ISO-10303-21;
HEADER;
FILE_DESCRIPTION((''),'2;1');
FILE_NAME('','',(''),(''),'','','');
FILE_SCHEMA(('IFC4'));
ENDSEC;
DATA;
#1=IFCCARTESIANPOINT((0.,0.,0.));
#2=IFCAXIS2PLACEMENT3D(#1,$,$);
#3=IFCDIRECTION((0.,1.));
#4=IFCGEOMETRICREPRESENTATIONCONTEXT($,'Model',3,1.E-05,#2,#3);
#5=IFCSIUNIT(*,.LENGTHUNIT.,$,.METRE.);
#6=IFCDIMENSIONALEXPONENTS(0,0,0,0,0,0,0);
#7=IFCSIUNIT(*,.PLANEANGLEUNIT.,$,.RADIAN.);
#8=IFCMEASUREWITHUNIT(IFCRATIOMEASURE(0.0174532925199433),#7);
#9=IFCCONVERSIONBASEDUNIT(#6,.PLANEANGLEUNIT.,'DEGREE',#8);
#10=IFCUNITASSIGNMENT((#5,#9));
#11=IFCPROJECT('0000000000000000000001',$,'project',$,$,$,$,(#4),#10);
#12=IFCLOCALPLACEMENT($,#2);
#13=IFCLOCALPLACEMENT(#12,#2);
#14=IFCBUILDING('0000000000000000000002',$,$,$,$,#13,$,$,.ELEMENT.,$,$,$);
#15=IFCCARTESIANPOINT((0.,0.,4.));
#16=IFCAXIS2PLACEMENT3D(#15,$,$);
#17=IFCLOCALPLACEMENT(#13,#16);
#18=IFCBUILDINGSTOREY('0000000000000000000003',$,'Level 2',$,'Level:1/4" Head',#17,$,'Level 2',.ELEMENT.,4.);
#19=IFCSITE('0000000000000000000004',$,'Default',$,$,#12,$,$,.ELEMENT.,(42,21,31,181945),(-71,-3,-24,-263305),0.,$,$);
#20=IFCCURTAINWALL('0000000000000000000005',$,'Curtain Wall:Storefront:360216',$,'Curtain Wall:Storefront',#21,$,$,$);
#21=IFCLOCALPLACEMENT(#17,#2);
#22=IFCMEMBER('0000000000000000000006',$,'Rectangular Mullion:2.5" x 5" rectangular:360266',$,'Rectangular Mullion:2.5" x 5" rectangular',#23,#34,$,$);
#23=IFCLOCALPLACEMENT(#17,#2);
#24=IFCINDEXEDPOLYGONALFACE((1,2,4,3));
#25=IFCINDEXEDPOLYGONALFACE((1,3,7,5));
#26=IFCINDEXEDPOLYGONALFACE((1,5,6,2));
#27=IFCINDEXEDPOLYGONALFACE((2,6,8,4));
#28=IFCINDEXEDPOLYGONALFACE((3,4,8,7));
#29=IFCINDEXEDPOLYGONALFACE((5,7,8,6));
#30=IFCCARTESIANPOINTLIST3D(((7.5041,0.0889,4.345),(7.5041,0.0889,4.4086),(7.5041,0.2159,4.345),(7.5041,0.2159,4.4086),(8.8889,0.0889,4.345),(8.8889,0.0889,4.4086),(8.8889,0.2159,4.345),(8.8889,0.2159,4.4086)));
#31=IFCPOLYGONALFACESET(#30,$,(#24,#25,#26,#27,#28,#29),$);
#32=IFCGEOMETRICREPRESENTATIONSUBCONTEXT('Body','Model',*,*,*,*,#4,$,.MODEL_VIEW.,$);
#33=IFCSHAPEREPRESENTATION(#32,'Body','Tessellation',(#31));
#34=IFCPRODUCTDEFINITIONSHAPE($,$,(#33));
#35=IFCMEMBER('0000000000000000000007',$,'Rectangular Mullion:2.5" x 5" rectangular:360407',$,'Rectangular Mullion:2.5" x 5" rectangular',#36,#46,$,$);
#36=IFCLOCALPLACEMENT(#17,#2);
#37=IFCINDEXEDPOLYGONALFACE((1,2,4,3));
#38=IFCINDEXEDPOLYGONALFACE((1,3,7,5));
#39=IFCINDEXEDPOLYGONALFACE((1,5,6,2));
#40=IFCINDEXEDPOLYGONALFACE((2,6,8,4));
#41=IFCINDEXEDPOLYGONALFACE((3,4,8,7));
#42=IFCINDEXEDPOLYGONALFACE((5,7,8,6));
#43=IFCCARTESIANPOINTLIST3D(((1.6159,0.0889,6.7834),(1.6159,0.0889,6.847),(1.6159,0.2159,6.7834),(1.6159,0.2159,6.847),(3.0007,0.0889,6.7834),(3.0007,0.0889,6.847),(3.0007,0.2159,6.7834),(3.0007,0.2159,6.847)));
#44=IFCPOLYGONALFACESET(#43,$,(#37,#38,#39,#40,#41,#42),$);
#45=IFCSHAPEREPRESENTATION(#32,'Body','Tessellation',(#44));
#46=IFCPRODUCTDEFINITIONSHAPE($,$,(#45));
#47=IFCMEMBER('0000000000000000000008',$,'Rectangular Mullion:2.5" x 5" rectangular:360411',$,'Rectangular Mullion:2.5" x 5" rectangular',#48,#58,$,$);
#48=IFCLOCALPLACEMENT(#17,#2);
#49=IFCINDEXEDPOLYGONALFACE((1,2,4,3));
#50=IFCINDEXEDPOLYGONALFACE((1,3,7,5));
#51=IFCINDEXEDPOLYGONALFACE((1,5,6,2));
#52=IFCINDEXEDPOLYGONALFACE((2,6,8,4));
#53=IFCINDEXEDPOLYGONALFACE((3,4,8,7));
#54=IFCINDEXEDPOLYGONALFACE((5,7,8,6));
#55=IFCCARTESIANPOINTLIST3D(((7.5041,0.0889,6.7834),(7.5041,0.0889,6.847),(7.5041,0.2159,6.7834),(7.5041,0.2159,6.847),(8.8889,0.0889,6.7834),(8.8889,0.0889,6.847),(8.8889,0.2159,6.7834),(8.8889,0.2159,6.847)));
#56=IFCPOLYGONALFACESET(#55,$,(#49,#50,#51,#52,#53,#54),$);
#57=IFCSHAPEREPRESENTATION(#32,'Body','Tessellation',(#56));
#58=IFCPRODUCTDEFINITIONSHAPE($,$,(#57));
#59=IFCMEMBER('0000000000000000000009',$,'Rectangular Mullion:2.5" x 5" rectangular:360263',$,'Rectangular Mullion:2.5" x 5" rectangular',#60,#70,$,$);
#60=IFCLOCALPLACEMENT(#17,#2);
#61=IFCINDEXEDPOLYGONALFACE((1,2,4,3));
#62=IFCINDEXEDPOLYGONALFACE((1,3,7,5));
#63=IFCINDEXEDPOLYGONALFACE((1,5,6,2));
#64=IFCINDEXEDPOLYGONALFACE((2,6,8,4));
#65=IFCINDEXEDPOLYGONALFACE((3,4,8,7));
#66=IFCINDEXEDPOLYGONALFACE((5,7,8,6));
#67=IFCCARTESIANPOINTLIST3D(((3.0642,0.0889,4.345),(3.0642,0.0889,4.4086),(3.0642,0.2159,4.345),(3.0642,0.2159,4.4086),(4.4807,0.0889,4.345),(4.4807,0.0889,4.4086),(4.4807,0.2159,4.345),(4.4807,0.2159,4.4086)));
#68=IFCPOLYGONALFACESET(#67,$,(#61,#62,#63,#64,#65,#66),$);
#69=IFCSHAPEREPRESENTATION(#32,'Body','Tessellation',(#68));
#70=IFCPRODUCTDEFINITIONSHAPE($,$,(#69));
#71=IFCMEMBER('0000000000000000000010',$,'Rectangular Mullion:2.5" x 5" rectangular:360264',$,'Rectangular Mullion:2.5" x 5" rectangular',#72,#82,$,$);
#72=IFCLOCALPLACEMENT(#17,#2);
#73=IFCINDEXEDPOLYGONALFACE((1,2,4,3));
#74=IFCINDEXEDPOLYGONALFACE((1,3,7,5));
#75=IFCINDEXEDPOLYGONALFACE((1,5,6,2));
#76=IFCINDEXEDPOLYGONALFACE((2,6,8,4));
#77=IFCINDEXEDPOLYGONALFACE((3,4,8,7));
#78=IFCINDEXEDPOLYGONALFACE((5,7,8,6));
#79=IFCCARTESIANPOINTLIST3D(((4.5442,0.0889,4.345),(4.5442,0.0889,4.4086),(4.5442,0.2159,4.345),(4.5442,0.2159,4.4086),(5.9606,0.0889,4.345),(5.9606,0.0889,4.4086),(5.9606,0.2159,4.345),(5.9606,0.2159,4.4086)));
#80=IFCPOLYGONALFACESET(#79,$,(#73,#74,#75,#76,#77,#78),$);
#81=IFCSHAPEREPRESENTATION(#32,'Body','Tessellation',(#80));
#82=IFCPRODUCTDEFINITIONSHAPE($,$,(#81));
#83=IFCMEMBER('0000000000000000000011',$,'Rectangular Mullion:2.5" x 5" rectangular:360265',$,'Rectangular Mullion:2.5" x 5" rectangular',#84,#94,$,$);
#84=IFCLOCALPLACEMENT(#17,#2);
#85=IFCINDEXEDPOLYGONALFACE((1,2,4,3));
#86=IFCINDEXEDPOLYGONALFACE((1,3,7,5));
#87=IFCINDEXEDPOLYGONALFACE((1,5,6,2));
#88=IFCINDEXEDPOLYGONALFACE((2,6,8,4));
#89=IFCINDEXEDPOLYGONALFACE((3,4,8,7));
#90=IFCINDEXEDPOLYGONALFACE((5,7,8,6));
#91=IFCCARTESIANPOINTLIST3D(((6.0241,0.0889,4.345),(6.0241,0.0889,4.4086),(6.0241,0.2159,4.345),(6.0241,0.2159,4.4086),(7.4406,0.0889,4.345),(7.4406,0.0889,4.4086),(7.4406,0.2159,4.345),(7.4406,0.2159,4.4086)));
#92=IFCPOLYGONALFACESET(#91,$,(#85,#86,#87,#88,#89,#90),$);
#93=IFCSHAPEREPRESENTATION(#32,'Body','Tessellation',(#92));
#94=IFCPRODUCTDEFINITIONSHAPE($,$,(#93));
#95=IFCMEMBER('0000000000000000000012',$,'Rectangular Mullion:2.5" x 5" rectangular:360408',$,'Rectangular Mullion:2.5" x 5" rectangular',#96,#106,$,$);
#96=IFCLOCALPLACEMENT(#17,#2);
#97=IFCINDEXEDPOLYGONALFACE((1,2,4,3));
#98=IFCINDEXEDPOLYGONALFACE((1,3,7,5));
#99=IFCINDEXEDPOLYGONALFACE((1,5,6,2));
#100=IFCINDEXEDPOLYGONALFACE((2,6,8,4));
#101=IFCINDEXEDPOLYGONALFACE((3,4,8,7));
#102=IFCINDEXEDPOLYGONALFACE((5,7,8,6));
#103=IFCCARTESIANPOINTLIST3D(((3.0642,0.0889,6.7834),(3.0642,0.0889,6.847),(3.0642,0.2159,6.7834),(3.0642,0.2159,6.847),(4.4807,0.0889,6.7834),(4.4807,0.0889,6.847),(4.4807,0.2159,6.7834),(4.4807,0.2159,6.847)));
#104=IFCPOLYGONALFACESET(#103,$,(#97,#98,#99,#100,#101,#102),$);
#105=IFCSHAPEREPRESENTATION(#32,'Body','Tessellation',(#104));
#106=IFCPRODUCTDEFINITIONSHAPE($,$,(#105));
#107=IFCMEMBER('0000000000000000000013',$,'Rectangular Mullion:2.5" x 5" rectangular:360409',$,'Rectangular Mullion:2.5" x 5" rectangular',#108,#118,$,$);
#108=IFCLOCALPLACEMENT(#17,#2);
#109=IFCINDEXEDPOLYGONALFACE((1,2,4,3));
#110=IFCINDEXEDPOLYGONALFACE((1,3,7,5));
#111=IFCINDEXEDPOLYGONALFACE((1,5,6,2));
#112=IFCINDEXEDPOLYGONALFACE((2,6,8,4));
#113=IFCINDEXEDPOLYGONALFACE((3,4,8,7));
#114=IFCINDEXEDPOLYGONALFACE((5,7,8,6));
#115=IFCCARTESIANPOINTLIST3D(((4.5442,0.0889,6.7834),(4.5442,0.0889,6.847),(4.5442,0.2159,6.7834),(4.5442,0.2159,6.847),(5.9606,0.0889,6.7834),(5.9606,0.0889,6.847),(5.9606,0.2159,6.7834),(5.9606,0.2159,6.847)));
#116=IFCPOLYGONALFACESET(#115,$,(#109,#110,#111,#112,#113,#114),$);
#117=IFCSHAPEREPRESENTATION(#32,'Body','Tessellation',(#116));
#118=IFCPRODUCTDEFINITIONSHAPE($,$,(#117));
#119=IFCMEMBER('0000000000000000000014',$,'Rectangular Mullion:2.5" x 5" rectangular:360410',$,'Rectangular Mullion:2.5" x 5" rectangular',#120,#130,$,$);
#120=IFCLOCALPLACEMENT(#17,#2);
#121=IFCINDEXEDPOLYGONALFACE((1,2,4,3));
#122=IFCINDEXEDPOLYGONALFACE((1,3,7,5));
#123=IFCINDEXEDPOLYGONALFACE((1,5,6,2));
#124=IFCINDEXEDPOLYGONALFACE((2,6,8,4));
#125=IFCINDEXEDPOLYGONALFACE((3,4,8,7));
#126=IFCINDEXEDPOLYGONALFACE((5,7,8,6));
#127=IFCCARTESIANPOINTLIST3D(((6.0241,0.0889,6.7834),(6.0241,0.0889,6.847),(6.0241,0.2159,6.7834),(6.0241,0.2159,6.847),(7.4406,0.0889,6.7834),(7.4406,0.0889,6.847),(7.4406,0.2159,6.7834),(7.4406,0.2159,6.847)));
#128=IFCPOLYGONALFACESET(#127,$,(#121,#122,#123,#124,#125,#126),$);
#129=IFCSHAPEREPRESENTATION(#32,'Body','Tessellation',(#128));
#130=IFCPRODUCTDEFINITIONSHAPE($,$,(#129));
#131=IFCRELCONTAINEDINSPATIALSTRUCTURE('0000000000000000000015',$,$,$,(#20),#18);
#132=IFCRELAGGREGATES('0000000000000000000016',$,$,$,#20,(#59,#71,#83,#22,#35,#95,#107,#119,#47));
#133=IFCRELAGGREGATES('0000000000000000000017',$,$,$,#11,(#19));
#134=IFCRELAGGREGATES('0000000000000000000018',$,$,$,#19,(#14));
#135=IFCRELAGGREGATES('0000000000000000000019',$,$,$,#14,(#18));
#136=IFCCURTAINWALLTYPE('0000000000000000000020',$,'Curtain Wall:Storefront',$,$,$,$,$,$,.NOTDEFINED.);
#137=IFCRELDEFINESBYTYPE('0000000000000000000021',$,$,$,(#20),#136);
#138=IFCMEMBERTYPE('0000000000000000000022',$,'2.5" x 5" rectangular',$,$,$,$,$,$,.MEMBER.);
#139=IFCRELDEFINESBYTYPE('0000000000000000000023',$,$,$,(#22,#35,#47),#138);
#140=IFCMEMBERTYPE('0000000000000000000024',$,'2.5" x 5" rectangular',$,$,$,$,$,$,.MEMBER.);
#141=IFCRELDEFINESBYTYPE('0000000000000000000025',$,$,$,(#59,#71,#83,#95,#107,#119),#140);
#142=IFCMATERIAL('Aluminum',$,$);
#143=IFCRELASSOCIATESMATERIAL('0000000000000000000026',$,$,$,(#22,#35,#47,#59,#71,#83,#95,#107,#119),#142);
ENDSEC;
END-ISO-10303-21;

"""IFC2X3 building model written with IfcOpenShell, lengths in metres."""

from ifc_helpers import new_model, entity, si_unit, converted_unit, direction, frame, origin, origin_2d_with_axis, place, context, subcontext, project, spatial, rectangle, extrude, source, transform, mapped, material, type_object, type_shapes, element, aggregate, save


model = new_model("IFC2X3")

# Units and contexts
model_context = context("Model", 3, precision=1e-05, world=origin(), true_north=direction((0.0, 1.0)))
body_context = subcontext(model_context, "Body", "Model", "MODEL_VIEW")
ifc_project = project(units=[si_unit("LENGTHUNIT", "METRE"), converted_unit("PLANEANGLEUNIT", "DEGREE", entity("IfcRatioMeasure", 0.0174532925199433), si_unit("PLANEANGLEUNIT", "RADIAN"), dimensions=[0, 0, 0, 0, 0, 0, 0])], contexts=[model_context])

# Site, building, storey
site_placement = place(None, origin())
site = spatial("IfcSite", under=ifc_project, at=site_placement, Name="Default", CompositionType="ELEMENT", RefLatitude=(42, 21, 31, 181945), RefLongitude=(-71, -3, -24, -263305), RefElevation=0.0)
building_placement = place(site_placement, origin())
building = spatial("IfcBuilding", under=site, at=building_placement, CompositionType="ELEMENT")
storey_placement = place(building_placement, frame((0.0, 0.0, 4.0)))
storey = spatial("IfcBuildingStorey", under=building, at=storey_placement, Name="Level 2", ObjectType="Level:1/4\" Head", LongName="Level 2", CompositionType="ELEMENT", Elevation=4.0)

# Curtain wall, members
curtain_wall_type = type_object("IfcCurtainWallType", Name="Curtain Wall:Storefront", PredefinedType="NOTDEFINED")
curtain_wall_placement = place(storey_placement, frame((0.0, 0.0, -4.0)))
curtain_wall = element("IfcCurtainWall", 1, at=curtain_wall_placement, inside=storey, type_object=curtain_wall_type, Name="Curtain Wall:Storefront:360216", ObjectType="Curtain Wall:Storefront")
ifc_material_1 = material(Name="Aluminum")
member_type_1 = type_object("IfcMemberType", Name="2.5\" x 5\" rectangular", PredefinedType="MEMBER")
shared_shape_1 = source(origin(), body_context, "Body", "SweptSolid", [
    extrude(rectangle(XDim=0.127, YDim=0.0635, at=origin_2d_with_axis()), frame((0.0, 0.0, -1.3848), z_axis=(0.0, 0.0, 1.0), x_axis=(0.0, -1.0, 0.0)), (0.0, 0.0, 1.0), 1.3848),
])
type_shapes(member_type_1, [shared_shape_1])
member_1_placement = place(storey_placement, frame((8.8889, 0.1524, 4.3768), z_axis=(1.0, 0.0, 0.0), x_axis=(0.0, 0.0, 1.0)))
member_1 = element("IfcMember", 2, at=member_1_placement, type_object=member_type_1, material=ifc_material_1, Name="Rectangular Mullion:2.5\" x 5\" rectangular:360266", ObjectType="Rectangular Mullion:2.5\" x 5\" rectangular", context=body_context, shape_type="MappedRepresentation", body=[
    mapped(shared_shape_1, transform((0.0, 0.0, 0.0), scale=1.0)),
])
member_2_placement = place(storey_placement, frame((3.0007, 0.1524, 6.8152), z_axis=(1.0, 0.0, 0.0), x_axis=(0.0, 0.0, 1.0)))
member_2 = element("IfcMember", 3, at=member_2_placement, type_object=member_type_1, material=ifc_material_1, Name="Rectangular Mullion:2.5\" x 5\" rectangular:360407", ObjectType="Rectangular Mullion:2.5\" x 5\" rectangular", context=body_context, shape_type="MappedRepresentation", body=[
    mapped(shared_shape_1, transform((0.0, 0.0, 0.0), scale=1.0)),
])
member_3_placement = place(storey_placement, frame((8.8889, 0.1524, 6.8152), z_axis=(1.0, 0.0, 0.0), x_axis=(0.0, 0.0, 1.0)))
member_3 = element("IfcMember", 4, at=member_3_placement, type_object=member_type_1, material=ifc_material_1, Name="Rectangular Mullion:2.5\" x 5\" rectangular:360411", ObjectType="Rectangular Mullion:2.5\" x 5\" rectangular", context=body_context, shape_type="MappedRepresentation", body=[
    mapped(shared_shape_1, transform((0.0, 0.0, 0.0), scale=1.0)),
])
member_type_2 = type_object("IfcMemberType", Name="2.5\" x 5\" rectangular", PredefinedType="MEMBER")
shared_shape_2 = source(origin(), body_context, "Body", "SweptSolid", [
    extrude(rectangle(XDim=0.127, YDim=0.0635, at=origin_2d_with_axis()), frame((0.0, 0.0, -1.4165), z_axis=(0.0, 0.0, 1.0), x_axis=(0.0, -1.0, 0.0)), (0.0, 0.0, 1.0), 1.4165),
])
type_shapes(member_type_2, [shared_shape_2])
member_4_placement = place(storey_placement, frame((4.4807, 0.1524, 4.3768), z_axis=(1.0, 0.0, 0.0), x_axis=(0.0, 0.0, 1.0)))
member_4 = element("IfcMember", 5, at=member_4_placement, type_object=member_type_2, material=ifc_material_1, Name="Rectangular Mullion:2.5\" x 5\" rectangular:360263", ObjectType="Rectangular Mullion:2.5\" x 5\" rectangular", context=body_context, shape_type="MappedRepresentation", body=[
    mapped(shared_shape_2, transform((0.0, 0.0, 0.0), scale=1.0)),
])
member_5_placement = place(storey_placement, frame((5.9606, 0.1524, 4.3768), z_axis=(1.0, 0.0, 0.0), x_axis=(0.0, 0.0, 1.0)))
member_5 = element("IfcMember", 6, at=member_5_placement, type_object=member_type_2, material=ifc_material_1, Name="Rectangular Mullion:2.5\" x 5\" rectangular:360264", ObjectType="Rectangular Mullion:2.5\" x 5\" rectangular", context=body_context, shape_type="MappedRepresentation", body=[
    mapped(shared_shape_2, transform((0.0, 0.0, 0.0), scale=1.0)),
])
member_6_placement = place(storey_placement, frame((7.4406, 0.1524, 4.3768), z_axis=(1.0, 0.0, 0.0), x_axis=(0.0, 0.0, 1.0)))
member_6 = element("IfcMember", 7, at=member_6_placement, type_object=member_type_2, material=ifc_material_1, Name="Rectangular Mullion:2.5\" x 5\" rectangular:360265", ObjectType="Rectangular Mullion:2.5\" x 5\" rectangular", context=body_context, shape_type="MappedRepresentation", body=[
    mapped(shared_shape_2, transform((0.0, 0.0, 0.0), scale=1.0)),
])
member_7_placement = place(storey_placement, frame((4.4807, 0.1524, 6.8152), z_axis=(1.0, 0.0, 0.0), x_axis=(0.0, 0.0, 1.0)))
member_7 = element("IfcMember", 8, at=member_7_placement, type_object=member_type_2, material=ifc_material_1, Name="Rectangular Mullion:2.5\" x 5\" rectangular:360408", ObjectType="Rectangular Mullion:2.5\" x 5\" rectangular", context=body_context, shape_type="MappedRepresentation", body=[
    mapped(shared_shape_2, transform((0.0, 0.0, 0.0), scale=1.0)),
])
member_8_placement = place(storey_placement, frame((5.9606, 0.1524, 6.8152), z_axis=(1.0, 0.0, 0.0), x_axis=(0.0, 0.0, 1.0)))
member_8 = element("IfcMember", 9, at=member_8_placement, type_object=member_type_2, material=ifc_material_1, Name="Rectangular Mullion:2.5\" x 5\" rectangular:360409", ObjectType="Rectangular Mullion:2.5\" x 5\" rectangular", context=body_context, shape_type="MappedRepresentation", body=[
    mapped(shared_shape_2, transform((0.0, 0.0, 0.0), scale=1.0)),
])
member_9_placement = place(storey_placement, frame((7.4406, 0.1524, 6.8152), z_axis=(1.0, 0.0, 0.0), x_axis=(0.0, 0.0, 1.0)))
member_9 = element("IfcMember", 10, at=member_9_placement, type_object=member_type_2, material=ifc_material_1, Name="Rectangular Mullion:2.5\" x 5\" rectangular:360410", ObjectType="Rectangular Mullion:2.5\" x 5\" rectangular", context=body_context, shape_type="MappedRepresentation", body=[
    mapped(shared_shape_2, transform((0.0, 0.0, 0.0), scale=1.0)),
])
aggregate(curtain_wall, [member_4, member_5, member_6, member_1, member_2, member_7, member_8, member_9, member_3])

save(model, "model.ifc")
